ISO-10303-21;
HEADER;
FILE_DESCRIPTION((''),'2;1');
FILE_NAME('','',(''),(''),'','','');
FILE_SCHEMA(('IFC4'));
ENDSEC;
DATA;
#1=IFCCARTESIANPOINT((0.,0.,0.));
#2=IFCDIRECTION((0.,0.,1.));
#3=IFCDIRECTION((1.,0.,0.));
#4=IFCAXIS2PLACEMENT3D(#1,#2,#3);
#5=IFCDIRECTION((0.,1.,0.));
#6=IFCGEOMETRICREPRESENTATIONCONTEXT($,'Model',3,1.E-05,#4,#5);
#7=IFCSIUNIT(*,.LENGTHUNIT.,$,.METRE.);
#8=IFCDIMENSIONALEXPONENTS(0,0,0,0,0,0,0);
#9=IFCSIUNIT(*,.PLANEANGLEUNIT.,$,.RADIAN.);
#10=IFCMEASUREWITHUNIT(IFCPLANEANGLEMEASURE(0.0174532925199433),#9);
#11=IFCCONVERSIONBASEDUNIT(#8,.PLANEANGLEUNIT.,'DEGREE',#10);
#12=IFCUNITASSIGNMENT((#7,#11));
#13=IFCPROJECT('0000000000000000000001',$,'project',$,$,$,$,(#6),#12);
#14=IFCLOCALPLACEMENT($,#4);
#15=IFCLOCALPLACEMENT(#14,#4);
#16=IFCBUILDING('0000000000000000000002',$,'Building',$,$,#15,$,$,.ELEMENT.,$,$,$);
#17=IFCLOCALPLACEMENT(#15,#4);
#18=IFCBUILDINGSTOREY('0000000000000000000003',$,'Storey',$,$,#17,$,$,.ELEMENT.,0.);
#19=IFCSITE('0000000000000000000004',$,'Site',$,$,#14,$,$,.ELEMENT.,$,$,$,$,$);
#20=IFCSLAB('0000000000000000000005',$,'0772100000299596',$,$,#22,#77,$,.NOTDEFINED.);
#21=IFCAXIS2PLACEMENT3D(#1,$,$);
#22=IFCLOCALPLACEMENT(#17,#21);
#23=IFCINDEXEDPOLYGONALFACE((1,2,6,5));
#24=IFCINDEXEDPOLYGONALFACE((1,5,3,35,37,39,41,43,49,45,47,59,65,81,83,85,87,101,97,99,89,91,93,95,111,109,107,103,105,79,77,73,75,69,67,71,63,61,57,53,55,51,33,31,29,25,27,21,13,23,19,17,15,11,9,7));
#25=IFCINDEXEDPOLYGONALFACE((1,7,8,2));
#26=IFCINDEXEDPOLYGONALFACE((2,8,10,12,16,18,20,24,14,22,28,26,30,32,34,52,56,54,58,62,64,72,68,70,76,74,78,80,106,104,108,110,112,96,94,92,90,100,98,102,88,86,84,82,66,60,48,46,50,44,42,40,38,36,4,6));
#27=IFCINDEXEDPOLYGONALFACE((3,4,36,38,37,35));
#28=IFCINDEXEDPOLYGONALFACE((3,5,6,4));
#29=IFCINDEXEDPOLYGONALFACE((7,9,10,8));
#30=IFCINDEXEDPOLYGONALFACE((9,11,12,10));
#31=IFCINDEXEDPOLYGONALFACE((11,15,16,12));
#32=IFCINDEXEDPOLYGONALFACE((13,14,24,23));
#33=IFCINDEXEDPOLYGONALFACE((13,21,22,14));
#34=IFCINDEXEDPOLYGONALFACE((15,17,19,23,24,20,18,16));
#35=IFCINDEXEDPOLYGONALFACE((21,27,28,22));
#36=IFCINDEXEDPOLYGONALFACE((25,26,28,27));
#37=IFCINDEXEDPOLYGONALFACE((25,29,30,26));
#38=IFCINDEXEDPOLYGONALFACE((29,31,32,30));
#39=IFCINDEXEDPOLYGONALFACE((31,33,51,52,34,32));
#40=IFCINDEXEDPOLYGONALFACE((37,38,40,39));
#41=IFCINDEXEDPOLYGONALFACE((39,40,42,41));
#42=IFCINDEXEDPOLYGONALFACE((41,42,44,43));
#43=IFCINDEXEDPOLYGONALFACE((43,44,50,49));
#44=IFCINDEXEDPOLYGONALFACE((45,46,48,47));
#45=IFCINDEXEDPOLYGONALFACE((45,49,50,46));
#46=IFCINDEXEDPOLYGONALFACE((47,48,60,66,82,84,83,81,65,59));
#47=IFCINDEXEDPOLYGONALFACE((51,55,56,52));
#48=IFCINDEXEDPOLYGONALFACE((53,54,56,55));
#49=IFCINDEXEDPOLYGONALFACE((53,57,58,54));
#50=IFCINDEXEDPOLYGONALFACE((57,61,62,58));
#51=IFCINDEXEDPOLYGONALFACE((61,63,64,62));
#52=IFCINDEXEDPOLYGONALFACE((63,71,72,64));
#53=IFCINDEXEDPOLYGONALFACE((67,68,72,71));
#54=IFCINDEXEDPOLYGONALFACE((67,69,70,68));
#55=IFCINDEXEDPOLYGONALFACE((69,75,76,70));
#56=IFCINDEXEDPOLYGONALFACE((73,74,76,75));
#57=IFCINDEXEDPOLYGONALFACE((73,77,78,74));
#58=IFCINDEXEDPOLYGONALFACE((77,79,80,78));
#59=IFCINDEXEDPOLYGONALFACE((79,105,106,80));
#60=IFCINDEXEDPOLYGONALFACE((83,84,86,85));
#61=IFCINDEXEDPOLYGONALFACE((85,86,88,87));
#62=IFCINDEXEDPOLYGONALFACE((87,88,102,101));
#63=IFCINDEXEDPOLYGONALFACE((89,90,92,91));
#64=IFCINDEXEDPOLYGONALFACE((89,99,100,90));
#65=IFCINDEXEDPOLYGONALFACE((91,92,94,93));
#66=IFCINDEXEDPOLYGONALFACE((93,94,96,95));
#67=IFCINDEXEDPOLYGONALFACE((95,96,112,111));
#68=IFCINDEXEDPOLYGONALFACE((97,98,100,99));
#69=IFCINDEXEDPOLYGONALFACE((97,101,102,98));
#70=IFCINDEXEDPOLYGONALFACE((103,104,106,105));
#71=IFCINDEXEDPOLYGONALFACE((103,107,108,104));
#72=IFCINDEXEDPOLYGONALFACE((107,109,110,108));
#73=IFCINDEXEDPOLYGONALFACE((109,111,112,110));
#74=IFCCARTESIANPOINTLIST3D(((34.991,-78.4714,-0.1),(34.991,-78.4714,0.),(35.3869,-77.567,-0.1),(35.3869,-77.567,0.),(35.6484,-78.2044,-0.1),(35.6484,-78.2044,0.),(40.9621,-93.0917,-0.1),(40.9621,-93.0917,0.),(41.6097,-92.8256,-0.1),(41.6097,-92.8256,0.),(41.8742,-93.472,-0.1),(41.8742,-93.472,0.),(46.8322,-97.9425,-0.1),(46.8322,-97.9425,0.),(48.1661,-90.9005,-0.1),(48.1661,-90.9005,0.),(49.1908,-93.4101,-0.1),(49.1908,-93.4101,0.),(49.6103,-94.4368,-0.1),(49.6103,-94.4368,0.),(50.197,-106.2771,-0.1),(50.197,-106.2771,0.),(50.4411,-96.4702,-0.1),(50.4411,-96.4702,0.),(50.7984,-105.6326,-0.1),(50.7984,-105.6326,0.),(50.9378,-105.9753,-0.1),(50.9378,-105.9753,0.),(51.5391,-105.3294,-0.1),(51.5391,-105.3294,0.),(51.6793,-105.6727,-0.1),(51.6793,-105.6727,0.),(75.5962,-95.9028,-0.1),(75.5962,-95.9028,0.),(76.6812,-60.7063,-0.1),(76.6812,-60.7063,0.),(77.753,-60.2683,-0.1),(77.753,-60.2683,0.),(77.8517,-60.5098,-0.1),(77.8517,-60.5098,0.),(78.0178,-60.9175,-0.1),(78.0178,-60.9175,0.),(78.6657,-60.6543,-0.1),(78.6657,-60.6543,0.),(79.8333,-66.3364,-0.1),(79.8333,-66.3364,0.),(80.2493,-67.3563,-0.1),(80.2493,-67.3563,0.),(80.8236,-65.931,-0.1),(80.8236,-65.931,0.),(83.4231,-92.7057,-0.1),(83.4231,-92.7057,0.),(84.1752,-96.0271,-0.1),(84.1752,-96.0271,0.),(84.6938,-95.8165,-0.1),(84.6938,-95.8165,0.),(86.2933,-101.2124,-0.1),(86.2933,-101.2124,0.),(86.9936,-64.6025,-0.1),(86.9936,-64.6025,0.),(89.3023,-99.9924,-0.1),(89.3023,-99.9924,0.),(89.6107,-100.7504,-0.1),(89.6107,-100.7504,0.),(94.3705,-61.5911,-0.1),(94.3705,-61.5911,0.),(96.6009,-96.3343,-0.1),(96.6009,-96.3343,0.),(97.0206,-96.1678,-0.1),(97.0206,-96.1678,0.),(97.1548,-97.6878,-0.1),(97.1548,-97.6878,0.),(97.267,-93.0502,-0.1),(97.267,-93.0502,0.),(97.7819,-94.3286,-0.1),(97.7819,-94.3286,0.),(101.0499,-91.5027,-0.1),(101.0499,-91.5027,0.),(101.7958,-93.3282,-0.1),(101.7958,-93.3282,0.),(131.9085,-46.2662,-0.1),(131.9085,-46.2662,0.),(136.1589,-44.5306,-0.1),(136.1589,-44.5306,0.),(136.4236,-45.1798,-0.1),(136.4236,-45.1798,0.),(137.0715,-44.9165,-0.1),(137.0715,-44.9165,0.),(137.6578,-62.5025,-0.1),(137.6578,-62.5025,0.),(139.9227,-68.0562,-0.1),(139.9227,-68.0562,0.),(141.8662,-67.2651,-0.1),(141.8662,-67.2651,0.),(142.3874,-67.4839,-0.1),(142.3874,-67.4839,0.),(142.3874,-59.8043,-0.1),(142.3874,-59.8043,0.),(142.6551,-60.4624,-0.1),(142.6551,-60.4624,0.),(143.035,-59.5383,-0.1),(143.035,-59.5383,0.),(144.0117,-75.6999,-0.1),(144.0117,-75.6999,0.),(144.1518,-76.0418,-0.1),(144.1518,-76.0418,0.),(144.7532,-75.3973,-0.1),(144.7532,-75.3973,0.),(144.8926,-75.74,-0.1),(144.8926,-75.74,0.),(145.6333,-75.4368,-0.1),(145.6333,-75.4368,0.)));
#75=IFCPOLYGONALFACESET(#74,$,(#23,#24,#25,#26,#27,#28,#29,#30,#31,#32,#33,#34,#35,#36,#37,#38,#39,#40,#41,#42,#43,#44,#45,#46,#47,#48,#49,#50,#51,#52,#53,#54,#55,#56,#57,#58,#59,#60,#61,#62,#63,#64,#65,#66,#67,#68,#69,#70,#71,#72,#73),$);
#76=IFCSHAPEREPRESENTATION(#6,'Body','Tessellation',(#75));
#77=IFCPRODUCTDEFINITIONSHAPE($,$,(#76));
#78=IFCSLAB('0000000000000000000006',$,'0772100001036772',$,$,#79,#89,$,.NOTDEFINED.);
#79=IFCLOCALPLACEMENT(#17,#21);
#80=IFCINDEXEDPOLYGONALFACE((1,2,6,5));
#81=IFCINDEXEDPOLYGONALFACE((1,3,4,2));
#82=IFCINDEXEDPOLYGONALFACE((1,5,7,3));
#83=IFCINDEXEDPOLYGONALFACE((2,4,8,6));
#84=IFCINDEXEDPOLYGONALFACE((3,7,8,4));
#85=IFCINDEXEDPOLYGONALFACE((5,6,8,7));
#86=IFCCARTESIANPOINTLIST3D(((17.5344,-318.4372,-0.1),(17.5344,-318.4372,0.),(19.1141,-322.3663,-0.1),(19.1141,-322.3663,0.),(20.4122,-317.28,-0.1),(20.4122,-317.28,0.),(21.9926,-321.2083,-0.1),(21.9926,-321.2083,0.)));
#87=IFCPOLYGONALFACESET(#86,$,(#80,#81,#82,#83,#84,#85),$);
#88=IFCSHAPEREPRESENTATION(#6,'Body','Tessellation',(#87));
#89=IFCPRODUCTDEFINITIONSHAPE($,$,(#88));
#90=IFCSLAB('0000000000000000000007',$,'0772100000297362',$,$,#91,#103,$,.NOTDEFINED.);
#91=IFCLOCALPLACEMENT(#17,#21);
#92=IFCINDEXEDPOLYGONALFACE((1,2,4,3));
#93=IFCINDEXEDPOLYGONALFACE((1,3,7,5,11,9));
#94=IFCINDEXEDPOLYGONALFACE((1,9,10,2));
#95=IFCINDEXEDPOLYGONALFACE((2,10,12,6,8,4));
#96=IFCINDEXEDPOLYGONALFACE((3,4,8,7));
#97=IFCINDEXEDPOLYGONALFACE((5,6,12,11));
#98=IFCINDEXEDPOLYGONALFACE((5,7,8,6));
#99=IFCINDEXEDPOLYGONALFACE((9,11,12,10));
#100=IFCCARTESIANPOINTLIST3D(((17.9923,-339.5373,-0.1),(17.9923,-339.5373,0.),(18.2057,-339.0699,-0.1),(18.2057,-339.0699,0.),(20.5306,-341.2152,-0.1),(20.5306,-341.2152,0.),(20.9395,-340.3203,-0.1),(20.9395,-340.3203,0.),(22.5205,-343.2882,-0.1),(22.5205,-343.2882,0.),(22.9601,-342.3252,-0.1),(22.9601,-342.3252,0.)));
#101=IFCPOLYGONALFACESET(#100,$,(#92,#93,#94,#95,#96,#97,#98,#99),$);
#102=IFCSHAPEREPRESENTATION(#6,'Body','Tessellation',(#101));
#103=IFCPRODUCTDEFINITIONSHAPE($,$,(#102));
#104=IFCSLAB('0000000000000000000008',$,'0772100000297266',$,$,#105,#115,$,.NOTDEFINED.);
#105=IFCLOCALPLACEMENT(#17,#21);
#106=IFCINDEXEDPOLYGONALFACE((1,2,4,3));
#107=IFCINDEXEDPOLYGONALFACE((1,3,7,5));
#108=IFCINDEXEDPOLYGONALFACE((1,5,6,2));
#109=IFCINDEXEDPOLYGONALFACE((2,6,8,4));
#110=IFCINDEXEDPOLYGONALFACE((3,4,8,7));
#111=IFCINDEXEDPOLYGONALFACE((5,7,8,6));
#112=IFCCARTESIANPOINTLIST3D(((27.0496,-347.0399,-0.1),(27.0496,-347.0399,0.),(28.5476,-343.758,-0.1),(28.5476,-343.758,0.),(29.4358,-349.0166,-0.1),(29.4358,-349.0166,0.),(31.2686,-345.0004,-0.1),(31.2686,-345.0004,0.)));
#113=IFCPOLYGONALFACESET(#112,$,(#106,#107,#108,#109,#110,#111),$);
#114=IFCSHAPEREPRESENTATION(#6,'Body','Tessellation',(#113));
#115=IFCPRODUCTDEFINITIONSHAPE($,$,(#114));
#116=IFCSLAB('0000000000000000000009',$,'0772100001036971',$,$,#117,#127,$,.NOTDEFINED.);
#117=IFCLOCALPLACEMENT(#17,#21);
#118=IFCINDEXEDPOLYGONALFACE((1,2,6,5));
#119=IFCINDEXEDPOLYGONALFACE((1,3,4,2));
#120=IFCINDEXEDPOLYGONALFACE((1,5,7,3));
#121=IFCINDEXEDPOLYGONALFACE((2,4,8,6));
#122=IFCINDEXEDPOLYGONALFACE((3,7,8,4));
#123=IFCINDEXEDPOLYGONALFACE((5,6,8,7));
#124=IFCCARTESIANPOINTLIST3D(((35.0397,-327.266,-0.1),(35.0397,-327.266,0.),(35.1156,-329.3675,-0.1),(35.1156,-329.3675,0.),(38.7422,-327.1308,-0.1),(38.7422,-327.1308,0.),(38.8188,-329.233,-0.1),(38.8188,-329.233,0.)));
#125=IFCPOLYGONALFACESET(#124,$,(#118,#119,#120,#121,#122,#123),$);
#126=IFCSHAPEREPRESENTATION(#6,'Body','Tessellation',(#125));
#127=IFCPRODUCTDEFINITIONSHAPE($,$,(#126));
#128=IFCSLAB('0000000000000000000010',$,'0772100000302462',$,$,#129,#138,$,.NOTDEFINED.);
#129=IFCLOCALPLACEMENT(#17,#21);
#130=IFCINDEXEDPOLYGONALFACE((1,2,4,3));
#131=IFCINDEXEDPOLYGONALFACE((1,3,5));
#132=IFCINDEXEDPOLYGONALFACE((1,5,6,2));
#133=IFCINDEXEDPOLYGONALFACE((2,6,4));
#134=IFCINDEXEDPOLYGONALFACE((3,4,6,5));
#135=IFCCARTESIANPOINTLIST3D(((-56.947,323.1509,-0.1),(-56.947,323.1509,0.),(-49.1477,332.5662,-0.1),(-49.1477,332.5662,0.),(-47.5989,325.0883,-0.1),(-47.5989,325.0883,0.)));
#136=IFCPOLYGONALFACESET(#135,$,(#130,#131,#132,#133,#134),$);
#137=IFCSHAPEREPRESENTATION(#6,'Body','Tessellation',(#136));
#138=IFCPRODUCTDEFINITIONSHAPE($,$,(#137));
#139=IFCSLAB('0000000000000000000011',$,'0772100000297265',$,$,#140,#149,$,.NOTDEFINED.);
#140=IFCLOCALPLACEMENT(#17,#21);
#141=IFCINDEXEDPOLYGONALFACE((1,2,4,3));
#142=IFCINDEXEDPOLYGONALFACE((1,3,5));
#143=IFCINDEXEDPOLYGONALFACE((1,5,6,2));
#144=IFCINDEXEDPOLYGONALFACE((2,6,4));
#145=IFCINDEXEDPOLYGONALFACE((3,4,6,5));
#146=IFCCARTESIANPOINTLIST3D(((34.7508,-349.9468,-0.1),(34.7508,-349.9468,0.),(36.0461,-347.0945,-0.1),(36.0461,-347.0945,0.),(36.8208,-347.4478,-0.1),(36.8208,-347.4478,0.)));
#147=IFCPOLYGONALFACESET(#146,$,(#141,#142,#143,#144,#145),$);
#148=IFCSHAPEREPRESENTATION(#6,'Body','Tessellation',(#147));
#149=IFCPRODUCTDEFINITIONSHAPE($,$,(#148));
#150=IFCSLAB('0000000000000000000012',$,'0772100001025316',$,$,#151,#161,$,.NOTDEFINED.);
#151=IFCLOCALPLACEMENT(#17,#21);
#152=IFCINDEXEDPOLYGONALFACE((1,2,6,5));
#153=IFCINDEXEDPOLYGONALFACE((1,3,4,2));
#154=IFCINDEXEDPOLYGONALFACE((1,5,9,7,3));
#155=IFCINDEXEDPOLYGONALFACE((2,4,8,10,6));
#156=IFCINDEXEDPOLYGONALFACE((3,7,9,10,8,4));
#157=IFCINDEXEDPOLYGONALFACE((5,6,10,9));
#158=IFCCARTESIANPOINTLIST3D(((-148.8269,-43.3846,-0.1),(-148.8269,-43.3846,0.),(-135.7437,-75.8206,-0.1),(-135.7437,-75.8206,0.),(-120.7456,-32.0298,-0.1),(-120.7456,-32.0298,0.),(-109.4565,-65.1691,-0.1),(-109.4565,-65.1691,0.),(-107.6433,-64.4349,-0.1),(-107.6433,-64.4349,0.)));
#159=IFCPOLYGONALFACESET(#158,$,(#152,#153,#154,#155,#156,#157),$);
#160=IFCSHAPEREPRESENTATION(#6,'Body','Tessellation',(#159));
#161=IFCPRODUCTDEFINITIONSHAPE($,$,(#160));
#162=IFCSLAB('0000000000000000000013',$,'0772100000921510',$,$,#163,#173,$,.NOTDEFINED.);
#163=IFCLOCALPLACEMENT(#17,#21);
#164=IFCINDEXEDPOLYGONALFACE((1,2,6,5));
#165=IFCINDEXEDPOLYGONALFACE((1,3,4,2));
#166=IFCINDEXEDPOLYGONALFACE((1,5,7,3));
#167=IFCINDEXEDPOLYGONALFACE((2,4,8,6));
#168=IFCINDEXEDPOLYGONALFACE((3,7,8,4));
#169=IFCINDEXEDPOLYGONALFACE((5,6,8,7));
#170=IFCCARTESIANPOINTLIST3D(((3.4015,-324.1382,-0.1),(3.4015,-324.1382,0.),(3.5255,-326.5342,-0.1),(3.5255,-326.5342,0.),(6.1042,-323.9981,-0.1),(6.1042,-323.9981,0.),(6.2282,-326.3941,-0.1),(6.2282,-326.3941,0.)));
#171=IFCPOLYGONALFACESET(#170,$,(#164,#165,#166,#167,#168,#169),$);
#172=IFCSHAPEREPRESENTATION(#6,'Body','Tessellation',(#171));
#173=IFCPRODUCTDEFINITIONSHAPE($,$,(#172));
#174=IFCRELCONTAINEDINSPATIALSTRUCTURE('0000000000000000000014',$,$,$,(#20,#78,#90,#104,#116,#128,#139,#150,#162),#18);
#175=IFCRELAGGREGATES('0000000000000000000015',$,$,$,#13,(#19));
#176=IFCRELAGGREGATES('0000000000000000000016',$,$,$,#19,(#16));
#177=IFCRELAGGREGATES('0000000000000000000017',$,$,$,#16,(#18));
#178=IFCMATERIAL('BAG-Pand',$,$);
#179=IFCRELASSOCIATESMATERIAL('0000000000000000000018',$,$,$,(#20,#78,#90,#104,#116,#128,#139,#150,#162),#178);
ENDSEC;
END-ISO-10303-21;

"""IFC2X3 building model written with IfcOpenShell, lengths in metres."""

from ifc_helpers import new_model, entity, si_unit, converted_unit, direction, frame, origin_with_axes, place, context, project, spatial, polyline, outline, extrude, material, element, save


model = new_model("IFC2X3")

# Units and contexts
model_context = context("Model", 3, precision=1e-05, world=origin_with_axes(), true_north=direction((0.0, 1.0, 0.0)))
ifc_project = project(units=[si_unit("LENGTHUNIT", "METRE"), converted_unit("PLANEANGLEUNIT", "DEGREE", entity("IfcPlaneAngleMeasure", 0.0174532925199433), si_unit("PLANEANGLEUNIT", "RADIAN"), dimensions=[0, 0, 0, 0, 0, 0, 0])], contexts=[model_context])

# Site, building, storey
site_placement = place(None, origin_with_axes())
site = spatial("IfcSite", under=ifc_project, at=site_placement, Name="Site", CompositionType="ELEMENT")
building_placement = place(site_placement, origin_with_axes())
building = spatial("IfcBuilding", under=site, at=building_placement, Name="Building", CompositionType="ELEMENT")
storey_placement = place(building_placement, origin_with_axes())
storey = spatial("IfcBuildingStorey", under=building, at=storey_placement, Name="Storey", CompositionType="ELEMENT", Elevation=0.0)

# Slabs
ifc_material = material(Name="BAG-Pand")
slab_1_placement = place(storey_placement, frame((0.0, 0.0, -0.1), z_axis=(0.0, 0.0, 1.0), x_axis=(1.0, 0.0, 0.0)))
element("IfcSlab", 1, at=slab_1_placement, inside=storey, material=ifc_material, Name="0772100000299596", PredefinedType="NOTDEFINED", context=model_context, shape_type="SweptSolid", body=[
    extrude(outline(polyline([(46.8322, -97.9425), (50.4411, -96.4702), (49.6103, -94.4368), (49.1908, -93.4101), (48.1661, -90.9005), (41.8742, -93.472), (41.6097, -92.8256), (40.9621, -93.0917), (34.991, -78.4714), (35.6484, -78.2044), (35.3869, -77.567), (76.6812, -60.7063), (77.753, -60.2683), (77.8517, -60.5098), (78.0178, -60.9175), (78.6657, -60.6543), (80.8236, -65.931), (79.8333, -66.3364), (80.2493, -67.3563), (86.9936, -64.6025), (94.3705, -61.5911), (131.9085, -46.2662), (136.1589, -44.5306), (136.4236, -45.1798), (137.0715, -44.9165), (143.035, -59.5383), (142.3874, -59.8043), (142.6551, -60.4624), (137.6578, -62.5025), (139.9227, -68.0562), (141.8662, -67.2651), (142.3874, -67.4839), (145.6333, -75.4368), (144.8926, -75.74), (144.7532, -75.3973), (144.0117, -75.6999), (144.1518, -76.0418), (101.7958, -93.3282), (101.0499, -91.5027), (97.267, -93.0502), (97.7819, -94.3286), (97.0206, -96.1678), (96.6009, -96.3343), (97.1548, -97.6878), (89.6107, -100.7504), (89.3023, -99.9924), (86.2933, -101.2124), (84.1752, -96.0271), (84.6938, -95.8165), (83.4231, -92.7057), (75.5962, -95.9028), (51.6793, -105.6727), (51.5391, -105.3294), (50.7984, -105.6326), (50.9378, -105.9753), (50.197, -106.2771), (46.8322, -97.9425)])), origin_with_axes(), (0.0, 0.0, 1.0), 0.1),
])
slab_2_placement = place(storey_placement, frame((0.0, 0.0, -0.1), z_axis=(0.0, 0.0, 1.0), x_axis=(1.0, 0.0, 0.0)))
element("IfcSlab", 2, at=slab_2_placement, inside=storey, material=ifc_material, Name="0772100001036772", PredefinedType="NOTDEFINED", context=model_context, shape_type="SweptSolid", body=[
    extrude(outline(polyline([(17.5344, -318.4372), (20.4122, -317.28), (21.9926, -321.2083), (19.1141, -322.3663), (17.5344, -318.4372)])), origin_with_axes(), (0.0, 0.0, 1.0), 0.1),
])
slab_3_placement = place(storey_placement, frame((0.0, 0.0, -0.1), z_axis=(0.0, 0.0, 1.0), x_axis=(1.0, 0.0, 0.0)))
element("IfcSlab", 3, at=slab_3_placement, inside=storey, material=ifc_material, Name="0772100000297362", PredefinedType="NOTDEFINED", context=model_context, shape_type="SweptSolid", body=[
    extrude(outline(polyline([(18.2057, -339.0699), (20.9395, -340.3203), (20.5306, -341.2152), (22.9601, -342.3252), (22.5205, -343.2882), (17.9923, -339.5373), (18.2057, -339.0699)])), origin_with_axes(), (0.0, 0.0, 1.0), 0.1),
])
slab_4_placement = place(storey_placement, frame((0.0, 0.0, -0.1), z_axis=(0.0, 0.0, 1.0), x_axis=(1.0, 0.0, 0.0)))
element("IfcSlab", 4, at=slab_4_placement, inside=storey, material=ifc_material, Name="0772100000297266", PredefinedType="NOTDEFINED", context=model_context, shape_type="SweptSolid", body=[
    extrude(outline(polyline([(28.5476, -343.758), (31.2686, -345.0004), (29.4358, -349.0166), (27.0496, -347.0399), (28.5476, -343.758)])), origin_with_axes(), (0.0, 0.0, 1.0), 0.1),
])
slab_5_placement = place(storey_placement, frame((0.0, 0.0, -0.1), z_axis=(0.0, 0.0, 1.0), x_axis=(1.0, 0.0, 0.0)))
element("IfcSlab", 5, at=slab_5_placement, inside=storey, material=ifc_material, Name="0772100001036971", PredefinedType="NOTDEFINED", context=model_context, shape_type="SweptSolid", body=[
    extrude(outline(polyline([(35.0397, -327.266), (38.7422, -327.1308), (38.8188, -329.233), (35.1156, -329.3675), (35.0397, -327.266)])), origin_with_axes(), (0.0, 0.0, 1.0), 0.1),
])
slab_6_placement = place(storey_placement, frame((0.0, 0.0, -0.1), z_axis=(0.0, 0.0, 1.0), x_axis=(1.0, 0.0, 0.0)))
element("IfcSlab", 6, at=slab_6_placement, inside=storey, material=ifc_material, Name="0772100000302462", PredefinedType="NOTDEFINED", context=model_context, shape_type="SweptSolid", body=[
    extrude(outline(polyline([(-47.5989, 325.0883), (-56.947, 323.1509), (-49.1477, 332.5662), (-47.5989, 325.0883)])), origin_with_axes(), (0.0, 0.0, 1.0), 0.1),
])
slab_7_placement = place(storey_placement, frame((0.0, 0.0, -0.1), z_axis=(0.0, 0.0, 1.0), x_axis=(1.0, 0.0, 0.0)))
element("IfcSlab", 7, at=slab_7_placement, inside=storey, material=ifc_material, Name="0772100000297265", PredefinedType="NOTDEFINED", context=model_context, shape_type="SweptSolid", body=[
    extrude(outline(polyline([(36.0461, -347.0945), (36.8208, -347.4478), (34.7508, -349.9468), (36.0461, -347.0945)])), origin_with_axes(), (0.0, 0.0, 1.0), 0.1),
])
slab_8_placement = place(storey_placement, frame((0.0, 0.0, -0.1), z_axis=(0.0, 0.0, 1.0), x_axis=(1.0, 0.0, 0.0)))
element("IfcSlab", 8, at=slab_8_placement, inside=storey, material=ifc_material, Name="0772100001025316", PredefinedType="NOTDEFINED", context=model_context, shape_type="SweptSolid", body=[
    extrude(outline(polyline([(-148.8269, -43.3846), (-120.7456, -32.0298), (-107.6433, -64.4349), (-109.4565, -65.1691), (-135.7437, -75.8206), (-148.8269, -43.3846)])), origin_with_axes(), (0.0, 0.0, 1.0), 0.1),
])
slab_9_placement = place(storey_placement, frame((0.0, 0.0, -0.1), z_axis=(0.0, 0.0, 1.0), x_axis=(1.0, 0.0, 0.0)))
element("IfcSlab", 9, at=slab_9_placement, inside=storey, material=ifc_material, Name="0772100000921510", PredefinedType="NOTDEFINED", context=model_context, shape_type="SweptSolid", body=[
    extrude(outline(polyline([(3.4015, -324.1382), (6.1042, -323.9981), (6.2282, -326.3941), (3.5255, -326.5342), (3.4015, -324.1382)])), origin_with_axes(), (0.0, 0.0, 1.0), 0.1),
])

save(model, "model.ifc")
